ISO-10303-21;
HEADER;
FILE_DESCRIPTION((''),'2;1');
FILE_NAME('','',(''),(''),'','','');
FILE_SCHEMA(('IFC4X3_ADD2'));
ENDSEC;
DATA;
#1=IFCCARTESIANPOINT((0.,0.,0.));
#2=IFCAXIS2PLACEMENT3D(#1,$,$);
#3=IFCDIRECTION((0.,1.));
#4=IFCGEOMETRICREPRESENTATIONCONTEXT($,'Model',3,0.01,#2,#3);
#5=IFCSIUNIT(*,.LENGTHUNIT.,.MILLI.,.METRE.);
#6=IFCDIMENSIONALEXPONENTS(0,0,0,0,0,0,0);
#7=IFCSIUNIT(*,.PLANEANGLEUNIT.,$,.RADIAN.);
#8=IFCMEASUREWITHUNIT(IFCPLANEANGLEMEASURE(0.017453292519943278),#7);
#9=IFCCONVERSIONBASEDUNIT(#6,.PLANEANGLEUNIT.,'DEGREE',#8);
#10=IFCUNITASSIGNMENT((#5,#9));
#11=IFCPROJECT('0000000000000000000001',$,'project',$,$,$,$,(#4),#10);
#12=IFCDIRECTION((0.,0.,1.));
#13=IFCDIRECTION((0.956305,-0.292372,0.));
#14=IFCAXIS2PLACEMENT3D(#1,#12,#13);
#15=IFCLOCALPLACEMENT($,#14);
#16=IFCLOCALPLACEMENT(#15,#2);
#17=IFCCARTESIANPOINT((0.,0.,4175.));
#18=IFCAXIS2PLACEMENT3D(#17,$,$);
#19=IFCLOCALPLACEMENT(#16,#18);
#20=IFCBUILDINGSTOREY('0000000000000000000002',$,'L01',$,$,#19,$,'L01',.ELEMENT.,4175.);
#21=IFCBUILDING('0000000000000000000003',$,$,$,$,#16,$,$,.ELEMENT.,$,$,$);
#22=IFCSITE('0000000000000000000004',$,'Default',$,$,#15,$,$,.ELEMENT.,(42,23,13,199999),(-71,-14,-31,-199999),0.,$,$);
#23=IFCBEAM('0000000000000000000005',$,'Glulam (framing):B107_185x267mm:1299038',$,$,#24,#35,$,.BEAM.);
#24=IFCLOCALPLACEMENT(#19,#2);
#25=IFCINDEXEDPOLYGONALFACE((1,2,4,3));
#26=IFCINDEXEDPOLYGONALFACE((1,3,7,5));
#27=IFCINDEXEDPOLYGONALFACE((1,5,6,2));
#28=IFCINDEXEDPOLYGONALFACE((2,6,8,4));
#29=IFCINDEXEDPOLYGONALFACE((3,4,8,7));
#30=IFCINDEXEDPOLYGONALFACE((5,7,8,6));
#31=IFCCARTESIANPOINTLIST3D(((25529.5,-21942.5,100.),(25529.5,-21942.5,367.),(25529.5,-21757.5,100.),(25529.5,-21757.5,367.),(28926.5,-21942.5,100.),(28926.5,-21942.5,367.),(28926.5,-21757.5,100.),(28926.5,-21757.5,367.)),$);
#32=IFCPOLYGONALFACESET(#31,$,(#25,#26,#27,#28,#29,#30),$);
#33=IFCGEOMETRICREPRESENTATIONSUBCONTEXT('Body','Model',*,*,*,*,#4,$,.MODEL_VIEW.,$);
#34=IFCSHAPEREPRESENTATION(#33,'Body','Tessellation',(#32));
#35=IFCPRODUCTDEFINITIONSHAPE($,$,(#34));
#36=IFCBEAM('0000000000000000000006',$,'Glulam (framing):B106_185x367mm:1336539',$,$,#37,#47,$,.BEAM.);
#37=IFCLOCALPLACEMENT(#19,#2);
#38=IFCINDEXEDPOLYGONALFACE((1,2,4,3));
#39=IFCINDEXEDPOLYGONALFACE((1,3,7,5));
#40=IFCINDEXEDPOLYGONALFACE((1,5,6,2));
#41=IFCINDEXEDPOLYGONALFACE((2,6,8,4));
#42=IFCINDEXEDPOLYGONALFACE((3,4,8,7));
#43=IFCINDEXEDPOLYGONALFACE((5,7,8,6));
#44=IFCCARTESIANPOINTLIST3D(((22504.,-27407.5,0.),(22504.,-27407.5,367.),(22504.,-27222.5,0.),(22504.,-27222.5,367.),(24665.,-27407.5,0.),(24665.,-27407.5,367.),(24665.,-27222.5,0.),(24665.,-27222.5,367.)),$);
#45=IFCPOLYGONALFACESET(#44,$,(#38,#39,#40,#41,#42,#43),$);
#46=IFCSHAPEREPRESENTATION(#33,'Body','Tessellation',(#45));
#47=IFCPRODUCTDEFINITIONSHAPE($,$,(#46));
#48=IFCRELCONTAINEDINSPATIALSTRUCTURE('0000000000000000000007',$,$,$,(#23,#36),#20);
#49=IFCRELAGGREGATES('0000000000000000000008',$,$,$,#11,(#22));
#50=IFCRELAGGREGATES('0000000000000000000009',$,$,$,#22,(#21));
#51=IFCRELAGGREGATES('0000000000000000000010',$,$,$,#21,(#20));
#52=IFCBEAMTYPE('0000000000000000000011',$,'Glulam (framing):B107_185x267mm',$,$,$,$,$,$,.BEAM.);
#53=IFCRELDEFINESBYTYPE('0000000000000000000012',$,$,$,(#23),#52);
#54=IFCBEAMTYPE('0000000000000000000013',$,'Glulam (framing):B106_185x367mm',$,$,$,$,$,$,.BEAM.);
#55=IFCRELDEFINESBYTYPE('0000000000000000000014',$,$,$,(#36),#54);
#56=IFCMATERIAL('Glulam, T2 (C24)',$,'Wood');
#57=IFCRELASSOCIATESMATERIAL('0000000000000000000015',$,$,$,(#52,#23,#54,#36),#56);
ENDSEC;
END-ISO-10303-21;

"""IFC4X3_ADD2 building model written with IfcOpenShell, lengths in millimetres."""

from ifc_helpers import new_model, entity, si_unit, converted_unit, direction, frame, frame_2d, origin, origin_2d_with_axis, place, context, subcontext, project, spatial, rectangle, extrude, source, transform, mapped, material, material_profile, profile_set, profile_usage, type_object, type_shapes, element, save


model = new_model("IFC4X3_ADD2")

# Units and contexts
model_context = context("Model", 3, precision=0.01, world=origin(), true_north=direction((0.0, 1.0)))
body_context = subcontext(model_context, "Body", "Model", "MODEL_VIEW")
ifc_project = project(units=[si_unit("LENGTHUNIT", "METRE", prefix="MILLI"), converted_unit("PLANEANGLEUNIT", "DEGREE", entity("IfcPlaneAngleMeasure", 0.017453292519943278), si_unit("PLANEANGLEUNIT", "RADIAN"), dimensions=[0, 0, 0, 0, 0, 0, 0])], contexts=[model_context])

# Site, building, storey
site_placement = place(None, frame((0.0, 0.0, 0.0), z_axis=(0.0, 0.0, 1.0), x_axis=(0.956305, -0.292372, 0.0)))
site = spatial("IfcSite", under=ifc_project, at=site_placement, Name="Default", CompositionType="ELEMENT", RefLatitude=(42, 23, 13, 199999), RefLongitude=(-71, -14, -31, -199999), RefElevation=0.0)
building_placement = place(site_placement, origin())
building = spatial("IfcBuilding", under=site, at=building_placement, CompositionType="ELEMENT")
storey_placement = place(building_placement, frame((0.0, 0.0, 4175.0)))
storey = spatial("IfcBuildingStorey", under=building, at=storey_placement, Name="L01", LongName="L01", CompositionType="ELEMENT", Elevation=4175.0)

# Beams
ifc_material_1 = material(Name="Glulam, T2 (C24)", Category="Wood")
ifc_material_profile_1 = material_profile(ifc_material_1, rectangle(XDim=3269.5, YDim=185.0, at=origin_2d_with_axis()), Name="B107_185x267mm")
ifc_profile_set_1 = profile_set([ifc_material_profile_1], Name="B107_185x267mm")
ifc_profile_usage_1 = profile_usage(ifc_profile_set_1, cardinal=8)
beam_type_1 = type_object("IfcBeamType", Name="Glulam (framing):B107_185x267mm", PredefinedType="BEAM", material=ifc_profile_set_1)
shared_shape_1 = source(origin(), body_context, "Body", "SweptSolid", [
    extrude(rectangle(XDim=3397.0, YDim=185.0, at=origin_2d_with_axis()), frame((0.0, 0.0, -133.5), z_axis=(0.0, 0.0, 1.0), x_axis=(-1.0, 0.0, 0.0)), (0.0, 0.0, 1.0), 267.0),
])
type_shapes(beam_type_1, [shared_shape_1])
beam_1_placement = place(storey_placement, frame((27228.0, -21850.0, 233.5)))
element("IfcBeam", 1, at=beam_1_placement, inside=storey, type_object=beam_type_1, material=ifc_profile_usage_1, Name="Glulam (framing):B107_185x267mm:1299038", PredefinedType="BEAM", context=body_context, shape_type="MappedRepresentation", body=[
    mapped(shared_shape_1, transform((0.0, 0.0, 0.0), scale=1.0)),
])
ifc_material_profile_2 = material_profile(ifc_material_1, rectangle(XDim=2161.0, YDim=185.0, at=frame_2d((0.0, 0.0), x_axis=(1.0, 0.0))), Name="B106_185x367mm")
ifc_profile_set_2 = profile_set([ifc_material_profile_2], Name="B106_185x367mm")
ifc_profile_usage_2 = profile_usage(ifc_profile_set_2, cardinal=8)
beam_type_2 = type_object("IfcBeamType", Name="Glulam (framing):B106_185x367mm", PredefinedType="BEAM", material=ifc_profile_set_2)
shared_shape_2 = source(origin(), body_context, "Body", "SweptSolid", [
    extrude(rectangle(XDim=2161.0, YDim=185.0, at=frame_2d((0.0, 0.0), x_axis=(1.0, 0.0))), frame((-505.4, 0.0, -183.5), z_axis=(0.0, 0.0, 1.0), x_axis=(-1.0, 0.0, 0.0)), (0.0, 0.0, 1.0), 367.0),
])
type_shapes(beam_type_2, [shared_shape_2])
beam_2_placement = place(storey_placement, frame((24089.9, -27315.0, 183.5)))
element("IfcBeam", 2, at=beam_2_placement, inside=storey, type_object=beam_type_2, material=ifc_profile_usage_2, Name="Glulam (framing):B106_185x367mm:1336539", PredefinedType="BEAM", context=body_context, shape_type="MappedRepresentation", body=[
    mapped(shared_shape_2, transform((0.0, 0.0, 0.0), scale=1.0)),
])

save(model, "model.ifc")
